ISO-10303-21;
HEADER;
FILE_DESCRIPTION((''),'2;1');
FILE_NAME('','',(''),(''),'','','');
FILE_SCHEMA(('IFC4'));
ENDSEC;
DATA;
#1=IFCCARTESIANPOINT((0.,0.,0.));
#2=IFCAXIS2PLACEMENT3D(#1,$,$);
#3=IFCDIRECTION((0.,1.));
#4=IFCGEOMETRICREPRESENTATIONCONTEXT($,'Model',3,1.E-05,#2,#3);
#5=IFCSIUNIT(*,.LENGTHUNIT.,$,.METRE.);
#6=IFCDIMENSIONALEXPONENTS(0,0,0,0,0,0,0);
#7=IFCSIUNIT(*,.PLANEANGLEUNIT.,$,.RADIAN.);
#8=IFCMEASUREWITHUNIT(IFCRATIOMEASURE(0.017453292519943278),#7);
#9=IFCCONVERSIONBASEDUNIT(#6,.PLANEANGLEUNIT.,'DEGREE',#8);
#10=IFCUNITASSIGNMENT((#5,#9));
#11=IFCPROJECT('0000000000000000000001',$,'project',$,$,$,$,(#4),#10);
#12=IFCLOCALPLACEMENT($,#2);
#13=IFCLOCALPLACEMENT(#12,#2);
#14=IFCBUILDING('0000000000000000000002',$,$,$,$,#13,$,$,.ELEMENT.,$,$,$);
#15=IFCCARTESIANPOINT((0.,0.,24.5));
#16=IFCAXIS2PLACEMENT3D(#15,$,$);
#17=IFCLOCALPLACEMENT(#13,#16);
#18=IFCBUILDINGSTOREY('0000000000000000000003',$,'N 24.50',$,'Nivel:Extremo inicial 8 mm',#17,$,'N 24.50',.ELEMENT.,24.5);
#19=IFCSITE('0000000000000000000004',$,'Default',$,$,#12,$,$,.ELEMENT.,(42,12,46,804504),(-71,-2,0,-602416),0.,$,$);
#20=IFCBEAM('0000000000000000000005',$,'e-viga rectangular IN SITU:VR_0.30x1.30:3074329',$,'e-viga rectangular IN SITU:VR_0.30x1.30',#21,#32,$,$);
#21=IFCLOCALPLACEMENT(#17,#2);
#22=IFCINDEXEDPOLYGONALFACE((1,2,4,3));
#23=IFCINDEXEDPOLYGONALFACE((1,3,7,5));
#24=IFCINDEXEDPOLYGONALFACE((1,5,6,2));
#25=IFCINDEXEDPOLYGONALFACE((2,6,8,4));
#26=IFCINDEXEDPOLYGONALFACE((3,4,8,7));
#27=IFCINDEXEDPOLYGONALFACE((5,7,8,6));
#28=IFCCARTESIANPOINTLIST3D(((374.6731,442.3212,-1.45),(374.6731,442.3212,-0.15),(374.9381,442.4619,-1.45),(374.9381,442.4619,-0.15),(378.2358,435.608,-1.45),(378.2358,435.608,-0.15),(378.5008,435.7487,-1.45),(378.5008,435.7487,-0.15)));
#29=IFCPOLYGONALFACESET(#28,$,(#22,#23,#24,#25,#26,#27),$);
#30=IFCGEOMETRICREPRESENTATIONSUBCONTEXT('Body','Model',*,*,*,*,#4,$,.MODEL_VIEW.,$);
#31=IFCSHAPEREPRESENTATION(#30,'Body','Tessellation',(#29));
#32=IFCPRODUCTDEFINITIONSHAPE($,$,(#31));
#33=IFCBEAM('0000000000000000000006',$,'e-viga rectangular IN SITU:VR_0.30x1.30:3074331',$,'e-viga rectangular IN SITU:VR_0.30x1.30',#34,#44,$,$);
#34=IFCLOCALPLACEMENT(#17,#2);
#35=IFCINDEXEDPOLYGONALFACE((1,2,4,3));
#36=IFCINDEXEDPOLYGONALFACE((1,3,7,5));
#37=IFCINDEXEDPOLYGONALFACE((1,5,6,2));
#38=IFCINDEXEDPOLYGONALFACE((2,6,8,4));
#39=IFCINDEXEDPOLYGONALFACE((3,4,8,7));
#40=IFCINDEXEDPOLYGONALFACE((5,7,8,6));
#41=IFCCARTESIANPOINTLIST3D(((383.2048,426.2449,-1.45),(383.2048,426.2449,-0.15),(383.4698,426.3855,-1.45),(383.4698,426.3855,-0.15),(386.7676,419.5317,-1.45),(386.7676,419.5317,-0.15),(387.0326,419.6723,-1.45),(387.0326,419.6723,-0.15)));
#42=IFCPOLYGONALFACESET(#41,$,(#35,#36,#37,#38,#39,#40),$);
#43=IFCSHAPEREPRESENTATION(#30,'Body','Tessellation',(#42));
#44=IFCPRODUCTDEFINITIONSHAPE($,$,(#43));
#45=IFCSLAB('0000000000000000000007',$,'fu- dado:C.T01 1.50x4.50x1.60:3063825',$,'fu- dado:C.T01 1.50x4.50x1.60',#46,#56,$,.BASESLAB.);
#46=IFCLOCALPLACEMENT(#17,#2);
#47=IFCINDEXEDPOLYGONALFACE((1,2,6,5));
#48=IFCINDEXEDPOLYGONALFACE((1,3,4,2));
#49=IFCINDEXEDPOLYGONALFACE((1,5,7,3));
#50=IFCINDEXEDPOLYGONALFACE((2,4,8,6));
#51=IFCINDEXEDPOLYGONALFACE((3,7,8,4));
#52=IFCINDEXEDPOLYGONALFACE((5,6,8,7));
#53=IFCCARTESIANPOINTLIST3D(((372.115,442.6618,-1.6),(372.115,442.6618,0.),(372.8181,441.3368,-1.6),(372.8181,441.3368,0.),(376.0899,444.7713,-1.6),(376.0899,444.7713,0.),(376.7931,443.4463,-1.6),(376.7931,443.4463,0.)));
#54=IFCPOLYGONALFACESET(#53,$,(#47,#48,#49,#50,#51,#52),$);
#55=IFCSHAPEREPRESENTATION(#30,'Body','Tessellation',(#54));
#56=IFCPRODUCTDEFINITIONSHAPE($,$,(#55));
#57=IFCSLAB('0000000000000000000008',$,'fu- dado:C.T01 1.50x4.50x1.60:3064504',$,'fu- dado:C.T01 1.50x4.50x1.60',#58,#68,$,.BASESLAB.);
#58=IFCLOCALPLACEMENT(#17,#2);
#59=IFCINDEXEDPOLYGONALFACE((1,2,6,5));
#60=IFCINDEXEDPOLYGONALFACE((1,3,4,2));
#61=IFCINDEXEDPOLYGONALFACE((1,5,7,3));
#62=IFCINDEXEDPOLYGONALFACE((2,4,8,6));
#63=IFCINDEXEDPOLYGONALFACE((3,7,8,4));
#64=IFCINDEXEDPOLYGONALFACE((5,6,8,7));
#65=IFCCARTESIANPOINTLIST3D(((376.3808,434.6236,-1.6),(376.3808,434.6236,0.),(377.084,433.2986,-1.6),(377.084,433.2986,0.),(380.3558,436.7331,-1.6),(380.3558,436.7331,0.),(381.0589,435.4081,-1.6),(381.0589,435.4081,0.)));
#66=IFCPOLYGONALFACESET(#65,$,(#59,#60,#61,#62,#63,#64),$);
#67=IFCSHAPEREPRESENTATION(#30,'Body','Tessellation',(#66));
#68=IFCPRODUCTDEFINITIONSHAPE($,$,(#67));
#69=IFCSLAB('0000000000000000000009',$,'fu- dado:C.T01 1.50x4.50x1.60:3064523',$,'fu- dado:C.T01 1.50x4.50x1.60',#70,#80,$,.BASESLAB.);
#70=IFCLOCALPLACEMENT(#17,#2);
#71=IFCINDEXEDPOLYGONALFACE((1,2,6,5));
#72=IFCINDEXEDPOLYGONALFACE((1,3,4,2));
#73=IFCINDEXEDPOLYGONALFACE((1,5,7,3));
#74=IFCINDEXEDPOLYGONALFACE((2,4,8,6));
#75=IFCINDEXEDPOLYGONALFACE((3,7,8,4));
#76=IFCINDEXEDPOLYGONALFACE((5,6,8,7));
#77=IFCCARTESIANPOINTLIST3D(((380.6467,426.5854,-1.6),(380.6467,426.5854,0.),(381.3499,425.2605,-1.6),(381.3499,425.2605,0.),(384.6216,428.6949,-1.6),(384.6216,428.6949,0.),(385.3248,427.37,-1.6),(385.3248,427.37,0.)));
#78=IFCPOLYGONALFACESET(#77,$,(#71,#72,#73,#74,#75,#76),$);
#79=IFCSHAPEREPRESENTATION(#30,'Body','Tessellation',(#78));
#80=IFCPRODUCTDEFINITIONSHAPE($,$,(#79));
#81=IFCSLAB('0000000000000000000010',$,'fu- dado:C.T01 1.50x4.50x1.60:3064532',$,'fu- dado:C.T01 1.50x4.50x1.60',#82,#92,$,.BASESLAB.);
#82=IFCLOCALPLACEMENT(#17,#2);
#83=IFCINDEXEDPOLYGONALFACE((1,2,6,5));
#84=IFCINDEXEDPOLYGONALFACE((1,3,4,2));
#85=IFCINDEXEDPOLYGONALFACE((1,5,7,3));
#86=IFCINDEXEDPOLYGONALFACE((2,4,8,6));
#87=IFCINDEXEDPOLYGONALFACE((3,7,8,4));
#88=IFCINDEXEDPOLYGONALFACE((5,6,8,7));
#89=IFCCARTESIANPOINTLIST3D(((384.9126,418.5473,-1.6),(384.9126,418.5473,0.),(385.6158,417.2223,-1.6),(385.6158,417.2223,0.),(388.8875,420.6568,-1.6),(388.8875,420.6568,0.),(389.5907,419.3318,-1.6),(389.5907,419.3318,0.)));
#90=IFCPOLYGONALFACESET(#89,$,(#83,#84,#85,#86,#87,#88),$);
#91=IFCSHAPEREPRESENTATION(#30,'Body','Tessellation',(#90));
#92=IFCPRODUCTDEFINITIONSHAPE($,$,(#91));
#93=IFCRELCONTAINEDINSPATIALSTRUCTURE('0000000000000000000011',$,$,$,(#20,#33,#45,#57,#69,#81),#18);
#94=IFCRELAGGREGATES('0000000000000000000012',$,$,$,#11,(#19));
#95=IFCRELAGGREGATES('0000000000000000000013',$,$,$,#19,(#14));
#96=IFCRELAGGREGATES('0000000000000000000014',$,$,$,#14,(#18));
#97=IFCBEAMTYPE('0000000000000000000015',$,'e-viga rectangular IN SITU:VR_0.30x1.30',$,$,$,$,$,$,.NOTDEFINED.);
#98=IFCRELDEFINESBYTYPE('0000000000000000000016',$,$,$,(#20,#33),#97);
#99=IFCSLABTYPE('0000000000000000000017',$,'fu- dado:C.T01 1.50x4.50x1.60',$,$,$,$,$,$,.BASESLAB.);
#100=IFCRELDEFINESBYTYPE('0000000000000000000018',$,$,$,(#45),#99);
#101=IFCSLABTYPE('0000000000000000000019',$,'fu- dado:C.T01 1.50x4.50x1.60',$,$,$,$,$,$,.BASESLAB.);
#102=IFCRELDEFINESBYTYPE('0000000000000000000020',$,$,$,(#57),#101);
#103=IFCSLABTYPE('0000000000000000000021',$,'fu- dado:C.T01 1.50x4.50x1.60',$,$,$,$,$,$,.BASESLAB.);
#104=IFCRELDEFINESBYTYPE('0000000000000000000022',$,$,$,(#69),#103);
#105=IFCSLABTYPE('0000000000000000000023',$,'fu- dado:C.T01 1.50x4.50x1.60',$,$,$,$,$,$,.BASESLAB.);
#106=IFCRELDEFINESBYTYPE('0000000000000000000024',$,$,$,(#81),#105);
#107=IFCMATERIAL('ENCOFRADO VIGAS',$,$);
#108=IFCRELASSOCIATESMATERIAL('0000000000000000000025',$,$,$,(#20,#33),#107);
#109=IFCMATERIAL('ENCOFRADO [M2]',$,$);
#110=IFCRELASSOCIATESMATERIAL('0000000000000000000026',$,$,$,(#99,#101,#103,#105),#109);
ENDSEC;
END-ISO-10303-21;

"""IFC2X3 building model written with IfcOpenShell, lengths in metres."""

from ifc_helpers import new_model, entity, si_unit, converted_unit, direction, frame, frame_2d, origin, origin_2d_with_axis, place, context, subcontext, project, spatial, rectangle, extrude, material, type_object, element, save


model = new_model("IFC2X3")

# Units and contexts
model_context = context("Model", 3, precision=1e-05, world=origin(), true_north=direction((0.0, 1.0)))
body_context = subcontext(model_context, "Body", "Model", "MODEL_VIEW")
ifc_project = project(units=[si_unit("LENGTHUNIT", "METRE"), converted_unit("PLANEANGLEUNIT", "DEGREE", entity("IfcRatioMeasure", 0.017453292519943278), si_unit("PLANEANGLEUNIT", "RADIAN"), dimensions=[0, 0, 0, 0, 0, 0, 0])], contexts=[model_context])

# Site, building, storey
site_placement = place(None, origin())
site = spatial("IfcSite", under=ifc_project, at=site_placement, Name="Default", CompositionType="ELEMENT", RefLatitude=(42, 12, 46, 804504), RefLongitude=(-71, -2, 0, -602416), RefElevation=0.0)
building_placement = place(site_placement, origin())
building = spatial("IfcBuilding", under=site, at=building_placement, CompositionType="ELEMENT")
storey_placement = place(building_placement, frame((0.0, 0.0, 24.5)))
storey = spatial("IfcBuildingStorey", under=building, at=storey_placement, Name="N 24.50", ObjectType="Nivel:Extremo inicial 8 mm", LongName="N 24.50", CompositionType="ELEMENT", Elevation=24.5)

# Shared definitions
ifc_material_1 = material(Name="ENCOFRADO [M2]")

# Beams
ifc_material_2 = material(Name="ENCOFRADO VIGAS")
beam_type = type_object("IfcBeamType", Name="e-viga rectangular IN SITU:VR_0.30x1.30", PredefinedType="NOTDEFINED")
beam_1_placement = place(storey_placement, frame((374.8056, 442.3916, 0.0), z_axis=(0.0, 0.0, 1.0), x_axis=(0.468778, -0.883316, 0.0)))
element("IfcBeam", 1, at=beam_1_placement, inside=storey, type_object=beam_type, material=ifc_material_2, Name="e-viga rectangular IN SITU:VR_0.30x1.30:3074329", ObjectType="e-viga rectangular IN SITU:VR_0.30x1.30", context=body_context, shape_type="SweptSolid", body=[
    extrude(rectangle(XDim=1.3, YDim=0.3, at=frame_2d((0.0, 0.0), x_axis=(1.0, 0.0))), frame((0.0, 0.0, -0.8), z_axis=(1.0, 0.0, 0.0), x_axis=(0.0, 0.0, -1.0)), (0.0, 0.0, 1.0), 7.6),
])
beam_2_placement = place(storey_placement, frame((383.3373, 426.3152, 0.0), z_axis=(0.0, 0.0, 1.0), x_axis=(0.468778, -0.883316, 0.0)))
element("IfcBeam", 2, at=beam_2_placement, inside=storey, type_object=beam_type, material=ifc_material_2, Name="e-viga rectangular IN SITU:VR_0.30x1.30:3074331", ObjectType="e-viga rectangular IN SITU:VR_0.30x1.30", context=body_context, shape_type="SweptSolid", body=[
    extrude(rectangle(XDim=1.3, YDim=0.3, at=frame_2d((0.0, 0.0), x_axis=(1.0, 0.0))), frame((0.0, 0.0, -0.8), z_axis=(1.0, 0.0, 0.0), x_axis=(0.0, 0.0, -1.0)), (0.0, 0.0, 1.0), 7.6),
])

# Slabs
slab_type_1 = type_object("IfcSlabType", Name="fu- dado:C.T01 1.50x4.50x1.60", PredefinedType="BASESLAB", material=ifc_material_1)
slab_1_placement = place(storey_placement, origin())
element("IfcSlab", 3, at=slab_1_placement, inside=storey, type_object=slab_type_1, Name="fu- dado:C.T01 1.50x4.50x1.60:3063825", ObjectType="fu- dado:C.T01 1.50x4.50x1.60", PredefinedType="BASESLAB", context=body_context, shape_type="SweptSolid", body=[
    extrude(rectangle(XDim=4.5, YDim=1.5, at=frame_2d((0.0, 0.0), x_axis=(1.0, 0.0))), frame((374.454, 443.0541, -1.6), z_axis=(0.0, 0.0, 1.0), x_axis=(-0.883316, -0.468778, 0.0)), (0.0, 0.0, 1.0), 1.6),
])
slab_type_2 = type_object("IfcSlabType", Name="fu- dado:C.T01 1.50x4.50x1.60", PredefinedType="BASESLAB", material=ifc_material_1)
slab_2_placement = place(storey_placement, origin())
element("IfcSlab", 4, at=slab_2_placement, inside=storey, type_object=slab_type_2, Name="fu- dado:C.T01 1.50x4.50x1.60:3064504", ObjectType="fu- dado:C.T01 1.50x4.50x1.60", PredefinedType="BASESLAB", context=body_context, shape_type="SweptSolid", body=[
    extrude(rectangle(XDim=4.5, YDim=1.5, at=origin_2d_with_axis()), frame((378.7199, 435.0159, -1.6), z_axis=(0.0, 0.0, 1.0), x_axis=(-0.883316, -0.468778, 0.0)), (0.0, 0.0, 1.0), 1.6),
])
slab_type_3 = type_object("IfcSlabType", Name="fu- dado:C.T01 1.50x4.50x1.60", PredefinedType="BASESLAB", material=ifc_material_1)
slab_3_placement = place(storey_placement, origin())
element("IfcSlab", 5, at=slab_3_placement, inside=storey, type_object=slab_type_3, Name="fu- dado:C.T01 1.50x4.50x1.60:3064523", ObjectType="fu- dado:C.T01 1.50x4.50x1.60", PredefinedType="BASESLAB", context=body_context, shape_type="SweptSolid", body=[
    extrude(rectangle(XDim=4.5, YDim=1.5, at=origin_2d_with_axis()), frame((382.9858, 426.9777, -1.6), z_axis=(0.0, 0.0, 1.0), x_axis=(-0.883316, -0.468778, 0.0)), (0.0, 0.0, 1.0), 1.6),
])
slab_type_4 = type_object("IfcSlabType", Name="fu- dado:C.T01 1.50x4.50x1.60", PredefinedType="BASESLAB", material=ifc_material_1)
slab_4_placement = place(storey_placement, origin())
element("IfcSlab", 6, at=slab_4_placement, inside=storey, type_object=slab_type_4, Name="fu- dado:C.T01 1.50x4.50x1.60:3064532", ObjectType="fu- dado:C.T01 1.50x4.50x1.60", PredefinedType="BASESLAB", context=body_context, shape_type="SweptSolid", body=[
    extrude(rectangle(XDim=4.5, YDim=1.5, at=origin_2d_with_axis()), frame((387.2516, 418.9395, -1.6), z_axis=(0.0, 0.0, 1.0), x_axis=(-0.883316, -0.468778, 0.0)), (0.0, 0.0, 1.0), 1.6),
])

save(model, "model.ifc")
